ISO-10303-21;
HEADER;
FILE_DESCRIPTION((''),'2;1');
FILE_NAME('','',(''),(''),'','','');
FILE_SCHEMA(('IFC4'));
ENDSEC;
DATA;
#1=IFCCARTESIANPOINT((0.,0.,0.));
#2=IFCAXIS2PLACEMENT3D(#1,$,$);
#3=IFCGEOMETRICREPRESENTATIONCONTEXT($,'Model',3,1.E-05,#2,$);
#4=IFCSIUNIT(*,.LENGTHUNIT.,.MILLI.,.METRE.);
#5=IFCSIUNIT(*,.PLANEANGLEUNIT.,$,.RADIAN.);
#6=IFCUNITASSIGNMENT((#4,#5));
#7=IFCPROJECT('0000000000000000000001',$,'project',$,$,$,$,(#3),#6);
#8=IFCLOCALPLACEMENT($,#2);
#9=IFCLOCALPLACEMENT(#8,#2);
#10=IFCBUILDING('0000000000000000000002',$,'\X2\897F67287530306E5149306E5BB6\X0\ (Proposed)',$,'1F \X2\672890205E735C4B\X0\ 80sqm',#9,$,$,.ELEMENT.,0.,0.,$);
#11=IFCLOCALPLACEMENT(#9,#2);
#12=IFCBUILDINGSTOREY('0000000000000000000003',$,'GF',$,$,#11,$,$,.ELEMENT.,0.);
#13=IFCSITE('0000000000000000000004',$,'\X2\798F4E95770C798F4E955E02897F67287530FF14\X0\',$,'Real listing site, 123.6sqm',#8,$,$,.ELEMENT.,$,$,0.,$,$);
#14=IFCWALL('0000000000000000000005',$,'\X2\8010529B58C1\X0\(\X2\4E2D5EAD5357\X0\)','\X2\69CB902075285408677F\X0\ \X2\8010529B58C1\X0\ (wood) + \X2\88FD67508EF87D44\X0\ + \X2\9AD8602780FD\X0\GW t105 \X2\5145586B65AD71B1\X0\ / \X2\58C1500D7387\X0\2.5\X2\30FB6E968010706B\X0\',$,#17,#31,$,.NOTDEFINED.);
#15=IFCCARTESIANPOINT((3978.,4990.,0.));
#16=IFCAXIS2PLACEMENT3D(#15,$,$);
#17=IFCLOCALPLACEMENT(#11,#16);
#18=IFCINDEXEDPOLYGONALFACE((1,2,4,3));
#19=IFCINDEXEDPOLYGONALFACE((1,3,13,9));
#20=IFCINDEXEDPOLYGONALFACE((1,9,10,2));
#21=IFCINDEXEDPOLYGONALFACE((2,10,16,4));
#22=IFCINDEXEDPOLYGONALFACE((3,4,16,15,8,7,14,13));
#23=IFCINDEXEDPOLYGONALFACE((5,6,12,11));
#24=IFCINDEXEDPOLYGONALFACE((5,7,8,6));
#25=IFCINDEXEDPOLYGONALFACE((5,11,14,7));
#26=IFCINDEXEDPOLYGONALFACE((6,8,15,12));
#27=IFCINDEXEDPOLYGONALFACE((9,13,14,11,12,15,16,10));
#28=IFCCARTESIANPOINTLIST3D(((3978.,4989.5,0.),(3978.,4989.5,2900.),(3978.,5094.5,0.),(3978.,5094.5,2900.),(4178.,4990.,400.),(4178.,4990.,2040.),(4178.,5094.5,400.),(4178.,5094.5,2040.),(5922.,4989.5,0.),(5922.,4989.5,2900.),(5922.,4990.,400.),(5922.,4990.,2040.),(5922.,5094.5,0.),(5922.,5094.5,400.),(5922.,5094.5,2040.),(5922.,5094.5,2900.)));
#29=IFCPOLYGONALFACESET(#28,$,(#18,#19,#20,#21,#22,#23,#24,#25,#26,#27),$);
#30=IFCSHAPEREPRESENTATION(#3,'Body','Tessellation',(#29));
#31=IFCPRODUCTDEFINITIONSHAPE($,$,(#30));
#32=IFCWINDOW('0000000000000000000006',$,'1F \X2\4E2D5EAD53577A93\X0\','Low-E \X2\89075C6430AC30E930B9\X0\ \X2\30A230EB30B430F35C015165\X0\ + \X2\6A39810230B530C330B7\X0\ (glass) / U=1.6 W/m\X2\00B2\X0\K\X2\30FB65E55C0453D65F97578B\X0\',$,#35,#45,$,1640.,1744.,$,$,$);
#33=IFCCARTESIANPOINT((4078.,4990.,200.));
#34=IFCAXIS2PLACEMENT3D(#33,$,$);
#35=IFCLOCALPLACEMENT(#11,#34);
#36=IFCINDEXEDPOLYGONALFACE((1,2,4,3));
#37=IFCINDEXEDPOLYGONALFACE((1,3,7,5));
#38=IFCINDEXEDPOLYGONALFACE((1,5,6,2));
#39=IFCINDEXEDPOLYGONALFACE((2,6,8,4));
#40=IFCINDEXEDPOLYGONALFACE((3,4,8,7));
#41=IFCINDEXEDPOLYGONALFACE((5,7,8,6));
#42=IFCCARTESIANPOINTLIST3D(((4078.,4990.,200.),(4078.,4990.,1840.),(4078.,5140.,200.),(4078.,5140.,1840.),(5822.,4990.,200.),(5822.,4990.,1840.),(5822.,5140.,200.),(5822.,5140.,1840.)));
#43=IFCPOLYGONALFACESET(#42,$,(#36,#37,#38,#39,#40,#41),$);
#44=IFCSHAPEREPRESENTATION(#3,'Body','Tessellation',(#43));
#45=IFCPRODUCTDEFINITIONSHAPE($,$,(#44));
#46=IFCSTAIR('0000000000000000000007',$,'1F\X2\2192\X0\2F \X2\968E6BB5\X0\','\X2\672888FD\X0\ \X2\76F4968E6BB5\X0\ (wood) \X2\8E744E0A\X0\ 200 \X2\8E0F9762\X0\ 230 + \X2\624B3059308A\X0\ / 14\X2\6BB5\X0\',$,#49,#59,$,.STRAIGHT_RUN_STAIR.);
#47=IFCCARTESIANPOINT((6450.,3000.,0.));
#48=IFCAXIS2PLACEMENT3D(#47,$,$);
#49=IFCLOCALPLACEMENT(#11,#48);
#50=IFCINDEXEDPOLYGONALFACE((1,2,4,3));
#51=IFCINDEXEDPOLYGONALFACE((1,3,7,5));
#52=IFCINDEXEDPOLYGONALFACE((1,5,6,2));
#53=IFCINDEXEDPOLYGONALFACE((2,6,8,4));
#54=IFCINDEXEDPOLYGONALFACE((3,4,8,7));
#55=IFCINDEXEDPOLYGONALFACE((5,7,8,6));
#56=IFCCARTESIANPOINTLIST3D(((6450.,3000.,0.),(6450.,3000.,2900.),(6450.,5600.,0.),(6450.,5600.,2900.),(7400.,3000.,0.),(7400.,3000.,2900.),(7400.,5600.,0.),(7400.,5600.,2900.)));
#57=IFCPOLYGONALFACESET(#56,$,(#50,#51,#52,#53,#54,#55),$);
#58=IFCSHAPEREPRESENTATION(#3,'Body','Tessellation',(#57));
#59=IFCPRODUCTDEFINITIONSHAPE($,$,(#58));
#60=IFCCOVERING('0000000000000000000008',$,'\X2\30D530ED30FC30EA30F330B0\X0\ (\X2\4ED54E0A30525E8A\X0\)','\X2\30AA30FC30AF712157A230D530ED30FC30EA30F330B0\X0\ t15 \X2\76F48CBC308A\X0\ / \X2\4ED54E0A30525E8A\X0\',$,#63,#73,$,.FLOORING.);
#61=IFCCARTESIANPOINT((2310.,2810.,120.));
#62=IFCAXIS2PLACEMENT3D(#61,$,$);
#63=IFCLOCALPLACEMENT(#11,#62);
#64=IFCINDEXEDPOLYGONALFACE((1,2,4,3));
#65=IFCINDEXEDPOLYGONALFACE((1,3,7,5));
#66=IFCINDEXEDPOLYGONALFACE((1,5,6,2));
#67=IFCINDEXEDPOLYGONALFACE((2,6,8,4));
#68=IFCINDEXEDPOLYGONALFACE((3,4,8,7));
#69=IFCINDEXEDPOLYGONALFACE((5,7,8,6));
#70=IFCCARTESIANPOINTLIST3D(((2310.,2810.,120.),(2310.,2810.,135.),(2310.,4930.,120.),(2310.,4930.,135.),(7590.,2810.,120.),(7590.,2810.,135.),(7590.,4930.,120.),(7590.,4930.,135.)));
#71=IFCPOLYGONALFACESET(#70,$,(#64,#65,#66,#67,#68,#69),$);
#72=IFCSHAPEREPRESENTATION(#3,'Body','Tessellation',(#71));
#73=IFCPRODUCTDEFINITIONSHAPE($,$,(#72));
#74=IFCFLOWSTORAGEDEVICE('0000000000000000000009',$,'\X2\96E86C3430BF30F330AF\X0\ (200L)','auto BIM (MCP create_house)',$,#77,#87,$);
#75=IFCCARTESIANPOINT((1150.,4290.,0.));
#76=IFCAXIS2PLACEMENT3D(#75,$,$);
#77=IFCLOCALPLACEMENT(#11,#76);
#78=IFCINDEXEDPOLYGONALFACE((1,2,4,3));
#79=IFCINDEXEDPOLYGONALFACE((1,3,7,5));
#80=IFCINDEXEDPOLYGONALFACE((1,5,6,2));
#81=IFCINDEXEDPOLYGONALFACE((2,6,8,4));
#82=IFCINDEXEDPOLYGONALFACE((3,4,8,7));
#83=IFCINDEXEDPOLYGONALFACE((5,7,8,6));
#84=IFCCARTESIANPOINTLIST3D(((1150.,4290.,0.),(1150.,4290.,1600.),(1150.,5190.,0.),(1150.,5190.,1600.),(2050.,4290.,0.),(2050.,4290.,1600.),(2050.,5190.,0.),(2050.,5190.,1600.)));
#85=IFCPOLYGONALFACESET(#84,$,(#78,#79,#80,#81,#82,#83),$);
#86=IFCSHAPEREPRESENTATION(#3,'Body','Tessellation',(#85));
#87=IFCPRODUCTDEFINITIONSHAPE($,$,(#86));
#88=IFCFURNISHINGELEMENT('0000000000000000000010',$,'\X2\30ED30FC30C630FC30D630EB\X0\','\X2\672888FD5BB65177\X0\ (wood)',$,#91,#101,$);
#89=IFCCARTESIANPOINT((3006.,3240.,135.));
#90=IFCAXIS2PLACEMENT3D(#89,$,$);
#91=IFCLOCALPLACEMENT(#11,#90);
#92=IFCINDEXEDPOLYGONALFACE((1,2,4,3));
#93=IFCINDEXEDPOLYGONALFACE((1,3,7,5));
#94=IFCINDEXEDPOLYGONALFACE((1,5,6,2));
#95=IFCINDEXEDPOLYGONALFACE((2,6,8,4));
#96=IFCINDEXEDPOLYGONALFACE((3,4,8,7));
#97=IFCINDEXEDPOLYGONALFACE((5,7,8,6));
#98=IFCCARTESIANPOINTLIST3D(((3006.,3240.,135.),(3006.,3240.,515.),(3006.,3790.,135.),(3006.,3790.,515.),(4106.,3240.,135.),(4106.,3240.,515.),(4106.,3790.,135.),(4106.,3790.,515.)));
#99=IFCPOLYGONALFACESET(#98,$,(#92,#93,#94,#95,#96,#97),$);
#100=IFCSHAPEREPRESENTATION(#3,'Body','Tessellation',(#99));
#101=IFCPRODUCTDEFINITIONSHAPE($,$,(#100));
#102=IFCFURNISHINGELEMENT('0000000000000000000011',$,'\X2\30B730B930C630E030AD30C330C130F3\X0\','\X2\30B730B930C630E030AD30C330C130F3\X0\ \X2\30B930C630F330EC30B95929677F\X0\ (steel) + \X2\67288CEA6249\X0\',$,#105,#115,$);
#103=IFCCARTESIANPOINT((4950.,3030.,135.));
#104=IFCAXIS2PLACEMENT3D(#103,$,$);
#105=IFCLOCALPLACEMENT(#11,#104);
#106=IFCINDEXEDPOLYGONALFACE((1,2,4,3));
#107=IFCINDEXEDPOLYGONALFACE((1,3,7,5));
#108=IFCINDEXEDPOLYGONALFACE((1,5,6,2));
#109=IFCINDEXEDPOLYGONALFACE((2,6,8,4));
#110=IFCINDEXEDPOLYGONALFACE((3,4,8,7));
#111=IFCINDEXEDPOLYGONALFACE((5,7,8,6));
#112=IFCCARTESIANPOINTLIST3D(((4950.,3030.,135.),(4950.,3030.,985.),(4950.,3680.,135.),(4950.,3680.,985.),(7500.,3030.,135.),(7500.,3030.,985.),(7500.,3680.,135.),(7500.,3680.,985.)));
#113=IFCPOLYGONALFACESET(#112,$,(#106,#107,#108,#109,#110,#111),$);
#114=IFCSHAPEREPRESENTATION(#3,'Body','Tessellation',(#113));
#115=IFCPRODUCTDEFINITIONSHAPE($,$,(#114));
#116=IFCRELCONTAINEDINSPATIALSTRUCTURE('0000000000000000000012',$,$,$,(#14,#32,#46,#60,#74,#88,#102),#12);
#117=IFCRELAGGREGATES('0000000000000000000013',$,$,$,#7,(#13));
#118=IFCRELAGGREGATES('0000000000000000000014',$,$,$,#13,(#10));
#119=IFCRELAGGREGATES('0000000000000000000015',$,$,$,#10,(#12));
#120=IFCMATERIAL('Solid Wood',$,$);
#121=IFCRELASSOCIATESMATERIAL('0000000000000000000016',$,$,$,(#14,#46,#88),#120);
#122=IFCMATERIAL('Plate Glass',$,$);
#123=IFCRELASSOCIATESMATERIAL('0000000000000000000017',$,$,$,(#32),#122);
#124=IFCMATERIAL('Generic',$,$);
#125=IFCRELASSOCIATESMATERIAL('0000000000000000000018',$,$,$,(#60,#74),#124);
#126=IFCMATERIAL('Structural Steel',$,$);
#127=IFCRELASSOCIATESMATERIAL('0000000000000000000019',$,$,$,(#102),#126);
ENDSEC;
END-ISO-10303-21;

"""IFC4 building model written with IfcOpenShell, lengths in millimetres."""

from ifc_helpers import new_model, si_unit, frame, frame_2d, origin, place, context, project, spatial, rectangle, extrude, material, element, fill, save


model = new_model("IFC4")

# Units and contexts
model_context = context("Model", 3, precision=1e-05, world=origin())
ifc_project = project(units=[si_unit("LENGTHUNIT", "METRE", prefix="MILLI"), si_unit("PLANEANGLEUNIT", "RADIAN")], contexts=[model_context])

# Site, building, storey
site_placement = place(None, origin())
site = spatial("IfcSite", under=ifc_project, at=site_placement, Name="福井県福井市西木田４", ObjectType="Real listing site, 123.6sqm", CompositionType="ELEMENT", RefElevation=0.0)
building_placement = place(site_placement, origin())
building = spatial("IfcBuilding", under=site, at=building_placement, Name="西木田の光の家 (Proposed)", ObjectType="1F 木造平屋 80sqm", CompositionType="ELEMENT", ElevationOfRefHeight=0.0, ElevationOfTerrain=0.0)
storey_placement = place(building_placement, origin())
storey = spatial("IfcBuildingStorey", under=building, at=storey_placement, Name="GF", CompositionType="ELEMENT", Elevation=0.0)

# Shared definitions
ifc_material_1 = material(Name="Solid Wood")

# Shared definitions
ifc_material_2 = material(Name="Plate Glass")

# Wall, opening, window
wall_1_placement = place(storey_placement, frame((3978.0, 4990.0, 0.0)))
wall_1 = element("IfcWall", 1, at=wall_1_placement, inside=storey, material=ifc_material_1, Name="耐力壁(中庭南)", Description="構造用合板 耐力壁 (wood) + 製材軸組 + 高性能GW t105 充填断熱 / 壁倍率2.5・準耐火", PredefinedType="NOTDEFINED", context=model_context, shape_type="SweptSolid", body=[
    extrude(rectangle(XDim=1944.0, YDim=105.0, at=frame_2d((972.0, 52.0))), frame((3978.0, 4990.0, 0.0)), (0.0, 0.0, 1.0), 2900.0),
])
opening_1_placement = place(storey_placement, frame((4078.0, 4990.0, 200.0)))
opening_1 = element("IfcOpeningElement", 2, at=opening_1_placement, cuts=wall_1, PredefinedType="NOTDEFINED", context=model_context, shape_type="SweptSolid", body=[
    extrude(rectangle(XDim=1744.0, YDim=150.0, at=frame_2d((872.0, 75.0))), frame((4078.0, 4990.0, 200.0)), (0.0, 0.0, 1.0), 1640.0),
])
window_1_placement = place(storey_placement, frame((4078.0, 4990.0, 200.0)))
window_1 = element("IfcWindow", 3, at=window_1_placement, inside=storey, material=ifc_material_2, Name="1F 中庭南窓", Description="Low-E 複層ガラス アルゴン封入 + 樹脂サッシ (glass) / U=1.6 W/m²K・日射取得型", OverallHeight=1640.0, OverallWidth=1744.0, context=model_context, shape_type="SweptSolid", body=[
    extrude(rectangle(XDim=1744.0, YDim=150.0, at=frame_2d((872.0, 75.0))), frame((4078.0, 4990.0, 200.0)), (0.0, 0.0, 1.0), 1640.0),
])
fill(opening_1, window_1)

# Stair
stair_placement = place(storey_placement, frame((6450.0, 3000.0, 0.0)))
element("IfcStair", 4, at=stair_placement, inside=storey, material=ifc_material_1, Name="1F→2F 階段", Description="木製 直階段 (wood) 蹴上 200 踏面 230 + 手すり / 14段", PredefinedType="STRAIGHT_RUN_STAIR", context=model_context, shape_type="SweptSolid", body=[
    extrude(rectangle(XDim=950.0, YDim=2600.0, at=frame_2d((475.0, 1300.0))), frame((6450.0, 3000.0, 0.0)), (0.0, 0.0, 1.0), 2900.0),
])

# Covering
ifc_material_3 = material(Name="Generic")
covering_placement = place(storey_placement, frame((2310.0, 2810.0, 120.0)))
element("IfcCovering", 5, at=covering_placement, inside=storey, material=ifc_material_3, Name="フローリング (仕上げ床)", Description="オーク無垢フローリング t15 直貼り / 仕上げ床", PredefinedType="FLOORING", context=model_context, shape_type="SweptSolid", body=[
    extrude(rectangle(XDim=5280.0, YDim=2120.0, at=frame_2d((2640.0, 1060.0))), frame((2310.0, 2810.0, 120.0)), (0.0, 0.0, 1.0), 15.0),
])

# Flow storage device
flow_storage_device_placement = place(storey_placement, frame((1150.0, 4290.0, 0.0)))
element("IfcFlowStorageDevice", 6, at=flow_storage_device_placement, inside=storey, material=ifc_material_3, Name="雨水タンク (200L)", Description="auto BIM (MCP create_house)", context=model_context, shape_type="SweptSolid", body=[
    extrude(rectangle(XDim=900.0, YDim=900.0, at=frame_2d((450.0, 450.0))), frame((1150.0, 4290.0, 0.0)), (0.0, 0.0, 1.0), 1600.0),
])

# Furnishing elements
furnishing_1_placement = place(storey_placement, frame((3006.0, 3240.0, 135.0)))
element("IfcFurnishingElement", 7, at=furnishing_1_placement, inside=storey, material=ifc_material_1, Name="ローテーブル", Description="木製家具 (wood)", context=model_context, shape_type="SweptSolid", body=[
    extrude(rectangle(XDim=1100.0, YDim=550.0, at=frame_2d((550.0, 275.0))), frame((3006.0, 3240.0, 135.0)), (0.0, 0.0, 1.0), 380.0),
])
ifc_material_4 = material(Name="Structural Steel")
furnishing_2_placement = place(storey_placement, frame((4950.0, 3030.0, 135.0)))
element("IfcFurnishingElement", 8, at=furnishing_2_placement, inside=storey, material=ifc_material_4, Name="システムキッチン", Description="システムキッチン ステンレス天板 (steel) + 木質扉", context=model_context, shape_type="SweptSolid", body=[
    extrude(rectangle(XDim=2550.0, YDim=650.0, at=frame_2d((1275.0, 325.0))), frame((4950.0, 3030.0, 135.0)), (0.0, 0.0, 1.0), 850.0),
])

save(model, "model.ifc")
